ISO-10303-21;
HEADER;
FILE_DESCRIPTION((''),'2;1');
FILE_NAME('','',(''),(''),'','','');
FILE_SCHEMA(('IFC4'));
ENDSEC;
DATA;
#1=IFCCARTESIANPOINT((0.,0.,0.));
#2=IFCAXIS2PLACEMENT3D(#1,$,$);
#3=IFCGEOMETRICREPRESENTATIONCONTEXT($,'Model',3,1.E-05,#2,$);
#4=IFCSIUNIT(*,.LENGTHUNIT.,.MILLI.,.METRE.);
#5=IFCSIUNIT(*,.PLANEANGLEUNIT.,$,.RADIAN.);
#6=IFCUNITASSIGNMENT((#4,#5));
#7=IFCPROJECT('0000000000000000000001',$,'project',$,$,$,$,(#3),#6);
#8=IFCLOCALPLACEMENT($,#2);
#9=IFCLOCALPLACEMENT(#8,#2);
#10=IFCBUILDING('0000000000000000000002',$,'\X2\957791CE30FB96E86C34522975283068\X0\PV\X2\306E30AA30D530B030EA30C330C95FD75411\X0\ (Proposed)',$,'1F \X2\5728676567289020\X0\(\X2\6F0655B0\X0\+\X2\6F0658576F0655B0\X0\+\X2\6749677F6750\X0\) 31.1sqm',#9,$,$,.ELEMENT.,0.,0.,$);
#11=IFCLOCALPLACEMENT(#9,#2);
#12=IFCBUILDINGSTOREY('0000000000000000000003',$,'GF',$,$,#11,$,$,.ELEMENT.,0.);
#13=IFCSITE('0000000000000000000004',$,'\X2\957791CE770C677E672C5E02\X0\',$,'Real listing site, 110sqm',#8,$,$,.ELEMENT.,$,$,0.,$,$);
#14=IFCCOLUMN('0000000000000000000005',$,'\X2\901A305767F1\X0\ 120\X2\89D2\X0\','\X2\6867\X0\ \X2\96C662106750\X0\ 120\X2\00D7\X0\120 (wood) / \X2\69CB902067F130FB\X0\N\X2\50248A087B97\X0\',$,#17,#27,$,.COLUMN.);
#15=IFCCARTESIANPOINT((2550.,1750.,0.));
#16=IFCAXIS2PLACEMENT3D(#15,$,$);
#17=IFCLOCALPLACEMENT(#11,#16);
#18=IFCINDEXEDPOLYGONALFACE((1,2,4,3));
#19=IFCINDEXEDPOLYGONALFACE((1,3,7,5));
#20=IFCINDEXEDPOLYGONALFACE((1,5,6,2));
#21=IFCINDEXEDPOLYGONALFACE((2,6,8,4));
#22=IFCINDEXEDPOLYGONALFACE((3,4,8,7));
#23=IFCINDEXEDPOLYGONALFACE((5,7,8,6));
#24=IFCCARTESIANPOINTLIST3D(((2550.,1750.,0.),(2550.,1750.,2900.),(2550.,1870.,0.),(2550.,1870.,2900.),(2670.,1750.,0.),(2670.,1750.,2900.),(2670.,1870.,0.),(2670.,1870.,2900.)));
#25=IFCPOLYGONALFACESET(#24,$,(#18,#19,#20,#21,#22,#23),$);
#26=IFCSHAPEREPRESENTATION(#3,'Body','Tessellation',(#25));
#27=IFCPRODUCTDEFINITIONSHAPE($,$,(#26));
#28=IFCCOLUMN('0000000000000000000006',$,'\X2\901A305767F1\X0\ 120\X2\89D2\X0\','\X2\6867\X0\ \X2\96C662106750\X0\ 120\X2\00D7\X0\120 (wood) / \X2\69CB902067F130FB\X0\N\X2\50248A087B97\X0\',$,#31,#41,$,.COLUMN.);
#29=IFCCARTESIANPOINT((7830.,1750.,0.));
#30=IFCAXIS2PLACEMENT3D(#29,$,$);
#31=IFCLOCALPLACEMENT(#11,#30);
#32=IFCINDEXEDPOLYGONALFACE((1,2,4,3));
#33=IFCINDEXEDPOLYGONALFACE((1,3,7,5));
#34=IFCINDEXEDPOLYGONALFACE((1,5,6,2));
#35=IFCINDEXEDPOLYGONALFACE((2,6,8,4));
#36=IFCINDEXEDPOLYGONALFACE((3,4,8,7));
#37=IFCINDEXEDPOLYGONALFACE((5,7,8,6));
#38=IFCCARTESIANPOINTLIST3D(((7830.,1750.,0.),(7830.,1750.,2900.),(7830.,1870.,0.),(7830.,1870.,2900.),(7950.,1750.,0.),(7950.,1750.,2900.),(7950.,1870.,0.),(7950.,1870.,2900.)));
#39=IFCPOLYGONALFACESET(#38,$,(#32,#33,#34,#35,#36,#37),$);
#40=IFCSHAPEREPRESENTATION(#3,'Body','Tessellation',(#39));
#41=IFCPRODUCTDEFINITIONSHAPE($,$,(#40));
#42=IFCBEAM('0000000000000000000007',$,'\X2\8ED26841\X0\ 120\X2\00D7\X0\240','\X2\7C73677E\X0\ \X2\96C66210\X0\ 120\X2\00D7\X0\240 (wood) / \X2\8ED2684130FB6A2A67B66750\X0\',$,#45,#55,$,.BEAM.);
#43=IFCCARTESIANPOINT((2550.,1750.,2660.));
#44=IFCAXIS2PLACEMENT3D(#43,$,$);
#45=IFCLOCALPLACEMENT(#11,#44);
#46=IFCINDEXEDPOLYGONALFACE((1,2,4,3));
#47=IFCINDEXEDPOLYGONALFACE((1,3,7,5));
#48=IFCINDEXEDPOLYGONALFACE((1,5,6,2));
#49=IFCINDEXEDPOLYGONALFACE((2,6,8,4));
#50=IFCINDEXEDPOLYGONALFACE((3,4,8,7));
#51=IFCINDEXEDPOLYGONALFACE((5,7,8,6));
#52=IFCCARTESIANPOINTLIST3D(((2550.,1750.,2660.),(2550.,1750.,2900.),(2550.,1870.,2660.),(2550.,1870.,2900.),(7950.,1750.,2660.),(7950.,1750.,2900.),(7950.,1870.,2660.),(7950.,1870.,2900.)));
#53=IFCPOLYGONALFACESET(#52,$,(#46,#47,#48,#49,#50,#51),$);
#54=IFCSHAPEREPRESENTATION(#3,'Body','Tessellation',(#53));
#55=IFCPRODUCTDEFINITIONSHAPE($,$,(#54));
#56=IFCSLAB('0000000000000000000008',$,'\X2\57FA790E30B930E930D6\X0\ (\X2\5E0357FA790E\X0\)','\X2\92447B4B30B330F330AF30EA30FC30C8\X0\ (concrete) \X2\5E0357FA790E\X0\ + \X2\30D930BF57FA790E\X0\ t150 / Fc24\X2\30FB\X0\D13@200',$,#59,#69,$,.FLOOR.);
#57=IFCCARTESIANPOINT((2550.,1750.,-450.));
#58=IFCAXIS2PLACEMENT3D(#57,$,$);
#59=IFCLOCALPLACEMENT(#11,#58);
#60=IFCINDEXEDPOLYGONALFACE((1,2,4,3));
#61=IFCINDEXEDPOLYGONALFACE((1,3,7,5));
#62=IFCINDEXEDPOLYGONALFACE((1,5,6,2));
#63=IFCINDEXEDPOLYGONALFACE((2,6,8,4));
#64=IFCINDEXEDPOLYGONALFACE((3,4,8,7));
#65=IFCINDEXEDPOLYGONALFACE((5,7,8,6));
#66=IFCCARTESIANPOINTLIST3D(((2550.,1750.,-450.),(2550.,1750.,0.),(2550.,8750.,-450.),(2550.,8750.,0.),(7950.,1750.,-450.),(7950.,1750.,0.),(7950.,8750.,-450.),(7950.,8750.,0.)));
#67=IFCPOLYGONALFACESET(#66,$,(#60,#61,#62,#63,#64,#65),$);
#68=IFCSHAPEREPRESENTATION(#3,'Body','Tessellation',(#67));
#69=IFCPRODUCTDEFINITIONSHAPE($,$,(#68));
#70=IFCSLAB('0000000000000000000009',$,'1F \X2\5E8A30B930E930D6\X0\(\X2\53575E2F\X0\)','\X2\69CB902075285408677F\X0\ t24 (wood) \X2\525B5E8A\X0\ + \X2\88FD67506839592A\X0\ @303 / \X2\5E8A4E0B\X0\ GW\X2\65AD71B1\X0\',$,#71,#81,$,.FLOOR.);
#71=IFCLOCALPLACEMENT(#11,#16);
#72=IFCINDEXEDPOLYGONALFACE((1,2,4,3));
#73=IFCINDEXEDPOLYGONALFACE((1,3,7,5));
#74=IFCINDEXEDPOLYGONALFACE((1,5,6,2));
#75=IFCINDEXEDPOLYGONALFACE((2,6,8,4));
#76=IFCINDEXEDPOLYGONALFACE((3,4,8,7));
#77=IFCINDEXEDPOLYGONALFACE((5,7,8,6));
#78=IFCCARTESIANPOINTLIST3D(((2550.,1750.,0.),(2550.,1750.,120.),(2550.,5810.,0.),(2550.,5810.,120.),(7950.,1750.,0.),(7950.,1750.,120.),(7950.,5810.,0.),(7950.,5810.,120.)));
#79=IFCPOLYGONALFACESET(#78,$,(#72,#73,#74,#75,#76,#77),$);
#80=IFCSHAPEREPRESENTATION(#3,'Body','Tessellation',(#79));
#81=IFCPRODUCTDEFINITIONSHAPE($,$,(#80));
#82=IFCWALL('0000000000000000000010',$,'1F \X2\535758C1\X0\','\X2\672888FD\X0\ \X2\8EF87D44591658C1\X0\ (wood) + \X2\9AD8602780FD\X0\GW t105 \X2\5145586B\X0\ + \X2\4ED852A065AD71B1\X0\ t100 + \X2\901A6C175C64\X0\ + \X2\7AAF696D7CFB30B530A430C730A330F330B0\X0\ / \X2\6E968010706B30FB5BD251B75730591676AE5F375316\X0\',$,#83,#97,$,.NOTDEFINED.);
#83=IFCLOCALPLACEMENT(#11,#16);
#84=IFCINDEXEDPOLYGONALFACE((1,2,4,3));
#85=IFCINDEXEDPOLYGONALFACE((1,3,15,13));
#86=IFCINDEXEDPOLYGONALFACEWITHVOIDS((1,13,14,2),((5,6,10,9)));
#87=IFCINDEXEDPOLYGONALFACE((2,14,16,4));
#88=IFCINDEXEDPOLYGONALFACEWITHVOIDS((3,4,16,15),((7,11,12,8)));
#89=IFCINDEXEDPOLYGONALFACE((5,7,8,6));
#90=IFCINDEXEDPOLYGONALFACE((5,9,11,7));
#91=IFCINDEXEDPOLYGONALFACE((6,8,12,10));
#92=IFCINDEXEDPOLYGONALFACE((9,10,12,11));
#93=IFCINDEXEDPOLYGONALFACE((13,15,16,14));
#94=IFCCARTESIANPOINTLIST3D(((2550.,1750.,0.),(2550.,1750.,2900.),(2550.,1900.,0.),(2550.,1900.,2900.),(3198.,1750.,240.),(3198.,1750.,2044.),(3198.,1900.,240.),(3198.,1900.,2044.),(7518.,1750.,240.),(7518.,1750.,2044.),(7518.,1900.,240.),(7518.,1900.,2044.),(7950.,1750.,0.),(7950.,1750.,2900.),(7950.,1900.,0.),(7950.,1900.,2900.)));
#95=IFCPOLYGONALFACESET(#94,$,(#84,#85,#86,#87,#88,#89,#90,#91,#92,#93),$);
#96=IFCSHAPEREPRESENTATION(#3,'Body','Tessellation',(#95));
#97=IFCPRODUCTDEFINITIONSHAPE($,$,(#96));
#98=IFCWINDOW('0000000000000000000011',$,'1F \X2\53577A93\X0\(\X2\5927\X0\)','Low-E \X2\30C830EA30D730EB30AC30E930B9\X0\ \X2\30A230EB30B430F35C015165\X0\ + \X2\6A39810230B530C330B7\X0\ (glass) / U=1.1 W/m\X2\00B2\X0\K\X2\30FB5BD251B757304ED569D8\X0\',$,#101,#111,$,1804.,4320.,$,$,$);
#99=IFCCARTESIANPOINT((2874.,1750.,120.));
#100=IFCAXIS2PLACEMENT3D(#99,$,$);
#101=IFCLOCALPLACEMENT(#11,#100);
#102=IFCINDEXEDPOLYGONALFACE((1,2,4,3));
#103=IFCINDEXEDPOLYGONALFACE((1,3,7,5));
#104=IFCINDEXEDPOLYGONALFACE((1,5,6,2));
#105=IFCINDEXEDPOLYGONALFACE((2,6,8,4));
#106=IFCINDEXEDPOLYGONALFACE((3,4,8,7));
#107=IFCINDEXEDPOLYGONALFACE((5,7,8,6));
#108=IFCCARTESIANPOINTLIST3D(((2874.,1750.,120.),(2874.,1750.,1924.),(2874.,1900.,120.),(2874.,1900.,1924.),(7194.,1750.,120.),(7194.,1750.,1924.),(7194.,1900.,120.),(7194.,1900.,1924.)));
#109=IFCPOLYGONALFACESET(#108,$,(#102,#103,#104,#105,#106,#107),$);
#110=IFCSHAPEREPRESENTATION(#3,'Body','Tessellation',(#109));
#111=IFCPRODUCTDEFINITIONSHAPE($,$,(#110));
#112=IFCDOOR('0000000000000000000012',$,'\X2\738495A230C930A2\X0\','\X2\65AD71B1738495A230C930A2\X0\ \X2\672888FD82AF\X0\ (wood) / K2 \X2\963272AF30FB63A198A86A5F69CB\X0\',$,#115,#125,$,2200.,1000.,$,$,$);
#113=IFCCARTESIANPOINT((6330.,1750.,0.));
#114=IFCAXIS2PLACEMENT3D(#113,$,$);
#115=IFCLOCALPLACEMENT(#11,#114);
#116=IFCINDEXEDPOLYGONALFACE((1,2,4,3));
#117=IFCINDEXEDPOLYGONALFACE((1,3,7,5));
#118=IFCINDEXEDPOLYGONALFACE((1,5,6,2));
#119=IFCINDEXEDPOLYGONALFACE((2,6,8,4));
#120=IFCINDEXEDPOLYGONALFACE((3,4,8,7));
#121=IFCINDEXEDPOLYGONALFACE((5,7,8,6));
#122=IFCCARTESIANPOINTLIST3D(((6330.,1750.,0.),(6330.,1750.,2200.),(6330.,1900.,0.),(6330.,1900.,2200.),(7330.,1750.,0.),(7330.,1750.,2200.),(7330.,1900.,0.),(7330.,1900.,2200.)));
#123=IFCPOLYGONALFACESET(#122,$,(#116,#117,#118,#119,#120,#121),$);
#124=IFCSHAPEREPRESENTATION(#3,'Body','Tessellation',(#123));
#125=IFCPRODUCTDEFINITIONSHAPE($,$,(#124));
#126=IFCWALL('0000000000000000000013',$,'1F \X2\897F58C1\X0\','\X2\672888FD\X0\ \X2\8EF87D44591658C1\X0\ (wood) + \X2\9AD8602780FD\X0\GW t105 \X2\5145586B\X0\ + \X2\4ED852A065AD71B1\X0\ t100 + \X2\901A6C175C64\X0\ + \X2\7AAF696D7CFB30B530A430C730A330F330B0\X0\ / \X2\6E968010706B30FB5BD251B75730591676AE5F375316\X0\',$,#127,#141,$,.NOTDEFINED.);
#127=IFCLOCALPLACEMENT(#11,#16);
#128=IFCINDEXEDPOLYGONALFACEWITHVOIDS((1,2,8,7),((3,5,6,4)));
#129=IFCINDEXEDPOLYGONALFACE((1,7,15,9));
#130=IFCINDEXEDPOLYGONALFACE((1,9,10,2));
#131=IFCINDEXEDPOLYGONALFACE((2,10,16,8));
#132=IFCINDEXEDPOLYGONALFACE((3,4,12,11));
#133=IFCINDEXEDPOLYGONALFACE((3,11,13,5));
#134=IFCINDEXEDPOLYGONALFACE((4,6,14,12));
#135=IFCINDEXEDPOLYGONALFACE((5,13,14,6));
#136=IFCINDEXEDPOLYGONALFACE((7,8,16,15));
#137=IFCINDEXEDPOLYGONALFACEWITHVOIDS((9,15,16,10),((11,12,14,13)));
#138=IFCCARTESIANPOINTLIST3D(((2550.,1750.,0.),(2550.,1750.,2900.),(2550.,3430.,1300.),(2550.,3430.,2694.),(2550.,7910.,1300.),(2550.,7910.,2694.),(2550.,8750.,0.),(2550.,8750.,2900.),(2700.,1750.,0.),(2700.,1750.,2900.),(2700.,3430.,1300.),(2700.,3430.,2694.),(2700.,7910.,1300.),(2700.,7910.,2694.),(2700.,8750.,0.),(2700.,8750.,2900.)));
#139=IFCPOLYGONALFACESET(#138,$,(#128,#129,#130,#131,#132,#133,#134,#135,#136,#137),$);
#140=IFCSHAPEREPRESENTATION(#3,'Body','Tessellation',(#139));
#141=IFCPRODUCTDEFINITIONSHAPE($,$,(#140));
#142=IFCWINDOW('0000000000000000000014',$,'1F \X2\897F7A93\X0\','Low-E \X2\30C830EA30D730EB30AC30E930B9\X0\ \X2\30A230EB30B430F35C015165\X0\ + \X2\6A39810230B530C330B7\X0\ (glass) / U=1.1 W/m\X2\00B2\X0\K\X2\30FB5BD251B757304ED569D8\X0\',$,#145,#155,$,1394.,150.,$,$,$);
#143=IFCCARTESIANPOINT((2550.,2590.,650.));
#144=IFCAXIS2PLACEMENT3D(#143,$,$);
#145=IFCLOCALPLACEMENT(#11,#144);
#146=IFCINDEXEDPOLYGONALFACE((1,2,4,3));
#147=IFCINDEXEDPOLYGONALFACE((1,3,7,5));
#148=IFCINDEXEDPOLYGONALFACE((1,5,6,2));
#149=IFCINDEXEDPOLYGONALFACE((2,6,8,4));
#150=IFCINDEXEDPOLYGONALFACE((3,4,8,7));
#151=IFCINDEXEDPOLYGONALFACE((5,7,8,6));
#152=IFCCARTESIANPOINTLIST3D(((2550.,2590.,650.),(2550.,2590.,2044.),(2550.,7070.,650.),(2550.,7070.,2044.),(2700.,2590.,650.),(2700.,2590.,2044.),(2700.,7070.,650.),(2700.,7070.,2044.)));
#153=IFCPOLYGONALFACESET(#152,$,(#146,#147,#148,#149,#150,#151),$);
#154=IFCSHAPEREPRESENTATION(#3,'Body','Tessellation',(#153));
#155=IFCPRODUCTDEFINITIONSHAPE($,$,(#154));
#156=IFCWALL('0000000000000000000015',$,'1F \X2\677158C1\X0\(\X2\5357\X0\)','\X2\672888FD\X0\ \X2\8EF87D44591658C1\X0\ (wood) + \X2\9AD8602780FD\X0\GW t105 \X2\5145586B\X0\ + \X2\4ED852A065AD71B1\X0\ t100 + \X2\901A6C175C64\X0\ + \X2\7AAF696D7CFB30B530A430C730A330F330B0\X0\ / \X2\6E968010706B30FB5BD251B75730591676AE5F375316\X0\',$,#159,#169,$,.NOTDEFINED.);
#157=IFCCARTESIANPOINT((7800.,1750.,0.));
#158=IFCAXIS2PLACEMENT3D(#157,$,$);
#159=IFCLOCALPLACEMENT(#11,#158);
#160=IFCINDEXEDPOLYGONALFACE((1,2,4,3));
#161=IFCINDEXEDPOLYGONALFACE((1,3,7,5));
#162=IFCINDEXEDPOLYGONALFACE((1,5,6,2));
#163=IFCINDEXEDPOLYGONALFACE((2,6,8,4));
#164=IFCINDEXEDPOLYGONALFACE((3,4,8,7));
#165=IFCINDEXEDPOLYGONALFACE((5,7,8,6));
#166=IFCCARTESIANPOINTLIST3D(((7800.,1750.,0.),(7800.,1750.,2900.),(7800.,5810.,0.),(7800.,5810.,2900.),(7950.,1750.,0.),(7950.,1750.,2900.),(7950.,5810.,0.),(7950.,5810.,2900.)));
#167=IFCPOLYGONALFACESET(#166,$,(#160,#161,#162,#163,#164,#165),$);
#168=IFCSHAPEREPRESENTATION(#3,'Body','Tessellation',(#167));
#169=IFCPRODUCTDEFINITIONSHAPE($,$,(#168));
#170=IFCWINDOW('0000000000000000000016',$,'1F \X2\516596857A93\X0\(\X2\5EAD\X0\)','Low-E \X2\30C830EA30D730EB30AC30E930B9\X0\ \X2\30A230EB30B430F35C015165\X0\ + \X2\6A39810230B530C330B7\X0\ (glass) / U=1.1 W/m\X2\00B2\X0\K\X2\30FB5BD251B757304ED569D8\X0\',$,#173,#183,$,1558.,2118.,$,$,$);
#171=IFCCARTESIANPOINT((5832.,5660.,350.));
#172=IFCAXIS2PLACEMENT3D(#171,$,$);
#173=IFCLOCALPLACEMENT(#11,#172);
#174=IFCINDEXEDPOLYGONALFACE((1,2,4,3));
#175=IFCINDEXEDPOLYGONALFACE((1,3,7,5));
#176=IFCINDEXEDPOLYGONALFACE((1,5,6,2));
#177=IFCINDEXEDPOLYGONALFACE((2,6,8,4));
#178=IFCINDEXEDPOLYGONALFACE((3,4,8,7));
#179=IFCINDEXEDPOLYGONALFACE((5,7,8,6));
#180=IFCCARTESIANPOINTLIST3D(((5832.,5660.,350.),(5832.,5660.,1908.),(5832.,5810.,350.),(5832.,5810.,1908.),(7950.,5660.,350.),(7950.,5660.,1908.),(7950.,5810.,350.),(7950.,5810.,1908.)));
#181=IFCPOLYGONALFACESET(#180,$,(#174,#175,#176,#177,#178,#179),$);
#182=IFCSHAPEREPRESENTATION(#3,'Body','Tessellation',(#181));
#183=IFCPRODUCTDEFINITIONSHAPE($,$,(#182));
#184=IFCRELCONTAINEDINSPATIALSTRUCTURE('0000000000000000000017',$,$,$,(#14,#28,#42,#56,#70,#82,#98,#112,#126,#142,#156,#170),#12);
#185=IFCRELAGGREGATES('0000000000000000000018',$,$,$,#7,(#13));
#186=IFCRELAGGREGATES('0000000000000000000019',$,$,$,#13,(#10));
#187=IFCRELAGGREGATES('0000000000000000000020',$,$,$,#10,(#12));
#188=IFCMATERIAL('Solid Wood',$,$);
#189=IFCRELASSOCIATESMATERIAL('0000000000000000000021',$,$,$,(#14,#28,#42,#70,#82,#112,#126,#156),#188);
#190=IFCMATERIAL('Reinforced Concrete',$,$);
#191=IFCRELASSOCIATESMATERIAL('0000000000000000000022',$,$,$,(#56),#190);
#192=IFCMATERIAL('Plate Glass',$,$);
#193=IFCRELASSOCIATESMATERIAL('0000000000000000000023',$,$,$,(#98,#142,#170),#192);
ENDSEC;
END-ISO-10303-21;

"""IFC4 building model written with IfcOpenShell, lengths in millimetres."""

from ifc_helpers import new_model, si_unit, frame, frame_2d, origin, place, context, project, spatial, rectangle, extrude, material, element, fill, save


model = new_model("IFC4")

# Units and contexts
model_context = context("Model", 3, precision=1e-05, world=origin())
ifc_project = project(units=[si_unit("LENGTHUNIT", "METRE", prefix="MILLI"), si_unit("PLANEANGLEUNIT", "RADIAN")], contexts=[model_context])

# Site, building, storey
site_placement = place(None, origin())
site = spatial("IfcSite", under=ifc_project, at=site_placement, Name="長野県松本市", ObjectType="Real listing site, 110sqm", CompositionType="ELEMENT", RefElevation=0.0)
building_placement = place(site_placement, origin())
building = spatial("IfcBuilding", under=site, at=building_placement, Name="長野・雨水利用とPVのオフグリッド志向 (Proposed)", ObjectType="1F 在来木造(漆喰+漆塗漆喰+杉板材) 31.1sqm", CompositionType="ELEMENT", ElevationOfRefHeight=0.0, ElevationOfTerrain=0.0)
storey_placement = place(building_placement, origin())
storey = spatial("IfcBuildingStorey", under=building, at=storey_placement, Name="GF", CompositionType="ELEMENT", Elevation=0.0)

# Columns
ifc_material_1 = material(Name="Solid Wood")
column_1_placement = place(storey_placement, frame((2550.0, 1750.0, 0.0)))
element("IfcColumn", 1, at=column_1_placement, inside=storey, material=ifc_material_1, Name="通し柱 120角", Description="桧 集成材 120×120 (wood) / 構造柱・N値計算", PredefinedType="COLUMN", context=model_context, shape_type="SweptSolid", body=[
    extrude(rectangle(XDim=120.0, YDim=120.0, at=frame_2d((60.0, 60.0))), frame((2550.0, 1750.0, 0.0)), (0.0, 0.0, 1.0), 2900.0),
])
column_2_placement = place(storey_placement, frame((7830.0, 1750.0, 0.0)))
element("IfcColumn", 2, at=column_2_placement, inside=storey, material=ifc_material_1, Name="通し柱 120角", Description="桧 集成材 120×120 (wood) / 構造柱・N値計算", PredefinedType="COLUMN", context=model_context, shape_type="SweptSolid", body=[
    extrude(rectangle(XDim=120.0, YDim=120.0, at=frame_2d((60.0, 60.0))), frame((7830.0, 1750.0, 0.0)), (0.0, 0.0, 1.0), 2900.0),
])

# Beam
beam_1_placement = place(storey_placement, frame((2550.0, 1750.0, 2660.0)))
element("IfcBeam", 3, at=beam_1_placement, inside=storey, material=ifc_material_1, Name="軒桁 120×240", Description="米松 集成 120×240 (wood) / 軒桁・横架材", PredefinedType="BEAM", context=model_context, shape_type="SweptSolid", body=[
    extrude(rectangle(XDim=5400.0, YDim=120.0, at=frame_2d((2700.0, 60.0))), frame((2550.0, 1750.0, 2660.0)), (0.0, 0.0, 1.0), 240.0),
])

# Slabs
ifc_material_2 = material(Name="Reinforced Concrete")
slab_1_placement = place(storey_placement, frame((2550.0, 1750.0, -450.0)))
element("IfcSlab", 4, at=slab_1_placement, inside=storey, material=ifc_material_2, Name="基礎スラブ (布基礎)", Description="鉄筋コンクリート (concrete) 布基礎 + ベタ基礎 t150 / Fc24・D13@200", PredefinedType="FLOOR", context=model_context, shape_type="SweptSolid", body=[
    extrude(rectangle(XDim=5400.0, YDim=7000.0, at=frame_2d((2700.0, 3500.0))), frame((2550.0, 1750.0, -450.0)), (0.0, 0.0, 1.0), 450.0),
])
slab_2_placement = place(storey_placement, frame((2550.0, 1750.0, 0.0)))
element("IfcSlab", 5, at=slab_2_placement, inside=storey, material=ifc_material_1, Name="1F 床スラブ(南帯)", Description="構造用合板 t24 (wood) 剛床 + 製材根太 @303 / 床下 GW断熱", PredefinedType="FLOOR", context=model_context, shape_type="SweptSolid", body=[
    extrude(rectangle(XDim=5400.0, YDim=4060.0, at=frame_2d((2700.0, 2030.0))), frame((2550.0, 1750.0, 0.0)), (0.0, 0.0, 1.0), 120.0),
])

# Wall, openings, window, door
wall_1_placement = place(storey_placement, frame((2550.0, 1750.0, 0.0)))
wall_1 = element("IfcWall", 6, at=wall_1_placement, inside=storey, material=ifc_material_1, Name="1F 南壁", Description="木製 軸組外壁 (wood) + 高性能GW t105 充填 + 付加断熱 t100 + 通気層 + 窯業系サイディング / 準耐火・寒冷地外皮強化", PredefinedType="NOTDEFINED", context=model_context, shape_type="SweptSolid", body=[
    extrude(rectangle(XDim=5400.0, YDim=150.0, at=frame_2d((2700.0, 75.0))), frame((2550.0, 1750.0, 0.0)), (0.0, 0.0, 1.0), 2900.0),
])
opening_1_placement = place(storey_placement, frame((2874.0, 1750.0, 120.0)))
opening_1 = element("IfcOpeningElement", 7, at=opening_1_placement, cuts=wall_1, PredefinedType="NOTDEFINED", context=model_context, shape_type="SweptSolid", body=[
    extrude(rectangle(XDim=4320.0, YDim=150.0, at=frame_2d((2160.0, 75.0))), frame((2874.0, 1750.0, 120.0)), (0.0, 0.0, 1.0), 1804.0),
])
opening_2_placement = place(storey_placement, frame((6330.0, 1750.0, 0.0)))
opening_2 = element("IfcOpeningElement", 8, at=opening_2_placement, cuts=wall_1, PredefinedType="NOTDEFINED", context=model_context, shape_type="SweptSolid", body=[
    extrude(rectangle(XDim=1000.0, YDim=150.0, at=frame_2d((500.0, 75.0))), frame((6330.0, 1750.0, 0.0)), (0.0, 0.0, 1.0), 2200.0),
])
ifc_material_3 = material(Name="Plate Glass")
window_1_placement = place(storey_placement, frame((2874.0, 1750.0, 120.0)))
window_1 = element("IfcWindow", 9, at=window_1_placement, inside=storey, material=ifc_material_3, Name="1F 南窓(大)", Description="Low-E トリプルガラス アルゴン封入 + 樹脂サッシ (glass) / U=1.1 W/m²K・寒冷地仕様", OverallHeight=1804.0, OverallWidth=4320.0, context=model_context, shape_type="SweptSolid", body=[
    extrude(rectangle(XDim=4320.0, YDim=150.0, at=frame_2d((2160.0, 75.0))), frame((2874.0, 1750.0, 120.0)), (0.0, 0.0, 1.0), 1804.0),
])
fill(opening_1, window_1)
door_1_placement = place(storey_placement, frame((6330.0, 1750.0, 0.0)))
door_1 = element("IfcDoor", 10, at=door_1_placement, inside=storey, material=ifc_material_1, Name="玄関ドア", Description="断熱玄関ドア 木製芯 (wood) / K2 防犯・採風機構", OverallHeight=2200.0, OverallWidth=1000.0, context=model_context, shape_type="SweptSolid", body=[
    extrude(rectangle(XDim=1000.0, YDim=150.0, at=frame_2d((500.0, 75.0))), frame((6330.0, 1750.0, 0.0)), (0.0, 0.0, 1.0), 2200.0),
])
fill(opening_2, door_1)

# Walls, openings, windows
wall_2_placement = place(storey_placement, frame((2550.0, 1750.0, 0.0)))
wall_2 = element("IfcWall", 11, at=wall_2_placement, inside=storey, material=ifc_material_1, Name="1F 西壁", Description="木製 軸組外壁 (wood) + 高性能GW t105 充填 + 付加断熱 t100 + 通気層 + 窯業系サイディング / 準耐火・寒冷地外皮強化", PredefinedType="NOTDEFINED", context=model_context, shape_type="SweptSolid", body=[
    extrude(rectangle(XDim=150.0, YDim=7000.0, at=frame_2d((75.0, 3500.0))), frame((2550.0, 1750.0, 0.0)), (0.0, 0.0, 1.0), 2900.0),
])
opening_3_placement = place(storey_placement, frame((2550.0, 2590.0, 650.0)))
opening_3 = element("IfcOpeningElement", 12, at=opening_3_placement, cuts=wall_2, PredefinedType="NOTDEFINED", context=model_context, shape_type="SweptSolid", body=[
    extrude(rectangle(XDim=150.0, YDim=4480.0, at=frame_2d((75.0, 2240.0))), frame((2550.0, 2590.0, 650.0)), (0.0, 0.0, 1.0), 1394.0),
])
window_2_placement = place(storey_placement, frame((2550.0, 2590.0, 650.0)))
window_2 = element("IfcWindow", 13, at=window_2_placement, inside=storey, material=ifc_material_3, Name="1F 西窓", Description="Low-E トリプルガラス アルゴン封入 + 樹脂サッシ (glass) / U=1.1 W/m²K・寒冷地仕様", OverallHeight=1394.0, OverallWidth=150.0, context=model_context, shape_type="SweptSolid", body=[
    extrude(rectangle(XDim=150.0, YDim=4480.0, at=frame_2d((75.0, 2240.0))), frame((2550.0, 2590.0, 650.0)), (0.0, 0.0, 1.0), 1394.0),
])
fill(opening_3, window_2)
wall_3_placement = place(storey_placement, frame((7800.0, 1750.0, 0.0)))
wall_3 = element("IfcWall", 14, at=wall_3_placement, inside=storey, material=ifc_material_1, Name="1F 東壁(南)", Description="木製 軸組外壁 (wood) + 高性能GW t105 充填 + 付加断熱 t100 + 通気層 + 窯業系サイディング / 準耐火・寒冷地外皮強化", PredefinedType="NOTDEFINED", context=model_context, shape_type="SweptSolid", body=[
    extrude(rectangle(XDim=150.0, YDim=4060.0, at=frame_2d((75.0, 2030.0))), frame((7800.0, 1750.0, 0.0)), (0.0, 0.0, 1.0), 2900.0),
])
opening_4_placement = place(storey_placement, frame((5832.0, 5660.0, 350.0)))
opening_4 = element("IfcOpeningElement", 15, at=opening_4_placement, cuts=wall_3, PredefinedType="NOTDEFINED", context=model_context, shape_type="SweptSolid", body=[
    extrude(rectangle(XDim=2118.0, YDim=150.0, at=frame_2d((1059.0, 75.0))), frame((5832.0, 5660.0, 350.0)), (0.0, 0.0, 1.0), 1558.0),
])
window_3_placement = place(storey_placement, frame((5832.0, 5660.0, 350.0)))
window_3 = element("IfcWindow", 16, at=window_3_placement, inside=storey, material=ifc_material_3, Name="1F 入隅窓(庭)", Description="Low-E トリプルガラス アルゴン封入 + 樹脂サッシ (glass) / U=1.1 W/m²K・寒冷地仕様", OverallHeight=1558.0, OverallWidth=2118.0, context=model_context, shape_type="SweptSolid", body=[
    extrude(rectangle(XDim=2118.0, YDim=150.0, at=frame_2d((1059.0, 75.0))), frame((5832.0, 5660.0, 350.0)), (0.0, 0.0, 1.0), 1558.0),
])
fill(opening_4, window_3)

save(model, "model.ifc")
